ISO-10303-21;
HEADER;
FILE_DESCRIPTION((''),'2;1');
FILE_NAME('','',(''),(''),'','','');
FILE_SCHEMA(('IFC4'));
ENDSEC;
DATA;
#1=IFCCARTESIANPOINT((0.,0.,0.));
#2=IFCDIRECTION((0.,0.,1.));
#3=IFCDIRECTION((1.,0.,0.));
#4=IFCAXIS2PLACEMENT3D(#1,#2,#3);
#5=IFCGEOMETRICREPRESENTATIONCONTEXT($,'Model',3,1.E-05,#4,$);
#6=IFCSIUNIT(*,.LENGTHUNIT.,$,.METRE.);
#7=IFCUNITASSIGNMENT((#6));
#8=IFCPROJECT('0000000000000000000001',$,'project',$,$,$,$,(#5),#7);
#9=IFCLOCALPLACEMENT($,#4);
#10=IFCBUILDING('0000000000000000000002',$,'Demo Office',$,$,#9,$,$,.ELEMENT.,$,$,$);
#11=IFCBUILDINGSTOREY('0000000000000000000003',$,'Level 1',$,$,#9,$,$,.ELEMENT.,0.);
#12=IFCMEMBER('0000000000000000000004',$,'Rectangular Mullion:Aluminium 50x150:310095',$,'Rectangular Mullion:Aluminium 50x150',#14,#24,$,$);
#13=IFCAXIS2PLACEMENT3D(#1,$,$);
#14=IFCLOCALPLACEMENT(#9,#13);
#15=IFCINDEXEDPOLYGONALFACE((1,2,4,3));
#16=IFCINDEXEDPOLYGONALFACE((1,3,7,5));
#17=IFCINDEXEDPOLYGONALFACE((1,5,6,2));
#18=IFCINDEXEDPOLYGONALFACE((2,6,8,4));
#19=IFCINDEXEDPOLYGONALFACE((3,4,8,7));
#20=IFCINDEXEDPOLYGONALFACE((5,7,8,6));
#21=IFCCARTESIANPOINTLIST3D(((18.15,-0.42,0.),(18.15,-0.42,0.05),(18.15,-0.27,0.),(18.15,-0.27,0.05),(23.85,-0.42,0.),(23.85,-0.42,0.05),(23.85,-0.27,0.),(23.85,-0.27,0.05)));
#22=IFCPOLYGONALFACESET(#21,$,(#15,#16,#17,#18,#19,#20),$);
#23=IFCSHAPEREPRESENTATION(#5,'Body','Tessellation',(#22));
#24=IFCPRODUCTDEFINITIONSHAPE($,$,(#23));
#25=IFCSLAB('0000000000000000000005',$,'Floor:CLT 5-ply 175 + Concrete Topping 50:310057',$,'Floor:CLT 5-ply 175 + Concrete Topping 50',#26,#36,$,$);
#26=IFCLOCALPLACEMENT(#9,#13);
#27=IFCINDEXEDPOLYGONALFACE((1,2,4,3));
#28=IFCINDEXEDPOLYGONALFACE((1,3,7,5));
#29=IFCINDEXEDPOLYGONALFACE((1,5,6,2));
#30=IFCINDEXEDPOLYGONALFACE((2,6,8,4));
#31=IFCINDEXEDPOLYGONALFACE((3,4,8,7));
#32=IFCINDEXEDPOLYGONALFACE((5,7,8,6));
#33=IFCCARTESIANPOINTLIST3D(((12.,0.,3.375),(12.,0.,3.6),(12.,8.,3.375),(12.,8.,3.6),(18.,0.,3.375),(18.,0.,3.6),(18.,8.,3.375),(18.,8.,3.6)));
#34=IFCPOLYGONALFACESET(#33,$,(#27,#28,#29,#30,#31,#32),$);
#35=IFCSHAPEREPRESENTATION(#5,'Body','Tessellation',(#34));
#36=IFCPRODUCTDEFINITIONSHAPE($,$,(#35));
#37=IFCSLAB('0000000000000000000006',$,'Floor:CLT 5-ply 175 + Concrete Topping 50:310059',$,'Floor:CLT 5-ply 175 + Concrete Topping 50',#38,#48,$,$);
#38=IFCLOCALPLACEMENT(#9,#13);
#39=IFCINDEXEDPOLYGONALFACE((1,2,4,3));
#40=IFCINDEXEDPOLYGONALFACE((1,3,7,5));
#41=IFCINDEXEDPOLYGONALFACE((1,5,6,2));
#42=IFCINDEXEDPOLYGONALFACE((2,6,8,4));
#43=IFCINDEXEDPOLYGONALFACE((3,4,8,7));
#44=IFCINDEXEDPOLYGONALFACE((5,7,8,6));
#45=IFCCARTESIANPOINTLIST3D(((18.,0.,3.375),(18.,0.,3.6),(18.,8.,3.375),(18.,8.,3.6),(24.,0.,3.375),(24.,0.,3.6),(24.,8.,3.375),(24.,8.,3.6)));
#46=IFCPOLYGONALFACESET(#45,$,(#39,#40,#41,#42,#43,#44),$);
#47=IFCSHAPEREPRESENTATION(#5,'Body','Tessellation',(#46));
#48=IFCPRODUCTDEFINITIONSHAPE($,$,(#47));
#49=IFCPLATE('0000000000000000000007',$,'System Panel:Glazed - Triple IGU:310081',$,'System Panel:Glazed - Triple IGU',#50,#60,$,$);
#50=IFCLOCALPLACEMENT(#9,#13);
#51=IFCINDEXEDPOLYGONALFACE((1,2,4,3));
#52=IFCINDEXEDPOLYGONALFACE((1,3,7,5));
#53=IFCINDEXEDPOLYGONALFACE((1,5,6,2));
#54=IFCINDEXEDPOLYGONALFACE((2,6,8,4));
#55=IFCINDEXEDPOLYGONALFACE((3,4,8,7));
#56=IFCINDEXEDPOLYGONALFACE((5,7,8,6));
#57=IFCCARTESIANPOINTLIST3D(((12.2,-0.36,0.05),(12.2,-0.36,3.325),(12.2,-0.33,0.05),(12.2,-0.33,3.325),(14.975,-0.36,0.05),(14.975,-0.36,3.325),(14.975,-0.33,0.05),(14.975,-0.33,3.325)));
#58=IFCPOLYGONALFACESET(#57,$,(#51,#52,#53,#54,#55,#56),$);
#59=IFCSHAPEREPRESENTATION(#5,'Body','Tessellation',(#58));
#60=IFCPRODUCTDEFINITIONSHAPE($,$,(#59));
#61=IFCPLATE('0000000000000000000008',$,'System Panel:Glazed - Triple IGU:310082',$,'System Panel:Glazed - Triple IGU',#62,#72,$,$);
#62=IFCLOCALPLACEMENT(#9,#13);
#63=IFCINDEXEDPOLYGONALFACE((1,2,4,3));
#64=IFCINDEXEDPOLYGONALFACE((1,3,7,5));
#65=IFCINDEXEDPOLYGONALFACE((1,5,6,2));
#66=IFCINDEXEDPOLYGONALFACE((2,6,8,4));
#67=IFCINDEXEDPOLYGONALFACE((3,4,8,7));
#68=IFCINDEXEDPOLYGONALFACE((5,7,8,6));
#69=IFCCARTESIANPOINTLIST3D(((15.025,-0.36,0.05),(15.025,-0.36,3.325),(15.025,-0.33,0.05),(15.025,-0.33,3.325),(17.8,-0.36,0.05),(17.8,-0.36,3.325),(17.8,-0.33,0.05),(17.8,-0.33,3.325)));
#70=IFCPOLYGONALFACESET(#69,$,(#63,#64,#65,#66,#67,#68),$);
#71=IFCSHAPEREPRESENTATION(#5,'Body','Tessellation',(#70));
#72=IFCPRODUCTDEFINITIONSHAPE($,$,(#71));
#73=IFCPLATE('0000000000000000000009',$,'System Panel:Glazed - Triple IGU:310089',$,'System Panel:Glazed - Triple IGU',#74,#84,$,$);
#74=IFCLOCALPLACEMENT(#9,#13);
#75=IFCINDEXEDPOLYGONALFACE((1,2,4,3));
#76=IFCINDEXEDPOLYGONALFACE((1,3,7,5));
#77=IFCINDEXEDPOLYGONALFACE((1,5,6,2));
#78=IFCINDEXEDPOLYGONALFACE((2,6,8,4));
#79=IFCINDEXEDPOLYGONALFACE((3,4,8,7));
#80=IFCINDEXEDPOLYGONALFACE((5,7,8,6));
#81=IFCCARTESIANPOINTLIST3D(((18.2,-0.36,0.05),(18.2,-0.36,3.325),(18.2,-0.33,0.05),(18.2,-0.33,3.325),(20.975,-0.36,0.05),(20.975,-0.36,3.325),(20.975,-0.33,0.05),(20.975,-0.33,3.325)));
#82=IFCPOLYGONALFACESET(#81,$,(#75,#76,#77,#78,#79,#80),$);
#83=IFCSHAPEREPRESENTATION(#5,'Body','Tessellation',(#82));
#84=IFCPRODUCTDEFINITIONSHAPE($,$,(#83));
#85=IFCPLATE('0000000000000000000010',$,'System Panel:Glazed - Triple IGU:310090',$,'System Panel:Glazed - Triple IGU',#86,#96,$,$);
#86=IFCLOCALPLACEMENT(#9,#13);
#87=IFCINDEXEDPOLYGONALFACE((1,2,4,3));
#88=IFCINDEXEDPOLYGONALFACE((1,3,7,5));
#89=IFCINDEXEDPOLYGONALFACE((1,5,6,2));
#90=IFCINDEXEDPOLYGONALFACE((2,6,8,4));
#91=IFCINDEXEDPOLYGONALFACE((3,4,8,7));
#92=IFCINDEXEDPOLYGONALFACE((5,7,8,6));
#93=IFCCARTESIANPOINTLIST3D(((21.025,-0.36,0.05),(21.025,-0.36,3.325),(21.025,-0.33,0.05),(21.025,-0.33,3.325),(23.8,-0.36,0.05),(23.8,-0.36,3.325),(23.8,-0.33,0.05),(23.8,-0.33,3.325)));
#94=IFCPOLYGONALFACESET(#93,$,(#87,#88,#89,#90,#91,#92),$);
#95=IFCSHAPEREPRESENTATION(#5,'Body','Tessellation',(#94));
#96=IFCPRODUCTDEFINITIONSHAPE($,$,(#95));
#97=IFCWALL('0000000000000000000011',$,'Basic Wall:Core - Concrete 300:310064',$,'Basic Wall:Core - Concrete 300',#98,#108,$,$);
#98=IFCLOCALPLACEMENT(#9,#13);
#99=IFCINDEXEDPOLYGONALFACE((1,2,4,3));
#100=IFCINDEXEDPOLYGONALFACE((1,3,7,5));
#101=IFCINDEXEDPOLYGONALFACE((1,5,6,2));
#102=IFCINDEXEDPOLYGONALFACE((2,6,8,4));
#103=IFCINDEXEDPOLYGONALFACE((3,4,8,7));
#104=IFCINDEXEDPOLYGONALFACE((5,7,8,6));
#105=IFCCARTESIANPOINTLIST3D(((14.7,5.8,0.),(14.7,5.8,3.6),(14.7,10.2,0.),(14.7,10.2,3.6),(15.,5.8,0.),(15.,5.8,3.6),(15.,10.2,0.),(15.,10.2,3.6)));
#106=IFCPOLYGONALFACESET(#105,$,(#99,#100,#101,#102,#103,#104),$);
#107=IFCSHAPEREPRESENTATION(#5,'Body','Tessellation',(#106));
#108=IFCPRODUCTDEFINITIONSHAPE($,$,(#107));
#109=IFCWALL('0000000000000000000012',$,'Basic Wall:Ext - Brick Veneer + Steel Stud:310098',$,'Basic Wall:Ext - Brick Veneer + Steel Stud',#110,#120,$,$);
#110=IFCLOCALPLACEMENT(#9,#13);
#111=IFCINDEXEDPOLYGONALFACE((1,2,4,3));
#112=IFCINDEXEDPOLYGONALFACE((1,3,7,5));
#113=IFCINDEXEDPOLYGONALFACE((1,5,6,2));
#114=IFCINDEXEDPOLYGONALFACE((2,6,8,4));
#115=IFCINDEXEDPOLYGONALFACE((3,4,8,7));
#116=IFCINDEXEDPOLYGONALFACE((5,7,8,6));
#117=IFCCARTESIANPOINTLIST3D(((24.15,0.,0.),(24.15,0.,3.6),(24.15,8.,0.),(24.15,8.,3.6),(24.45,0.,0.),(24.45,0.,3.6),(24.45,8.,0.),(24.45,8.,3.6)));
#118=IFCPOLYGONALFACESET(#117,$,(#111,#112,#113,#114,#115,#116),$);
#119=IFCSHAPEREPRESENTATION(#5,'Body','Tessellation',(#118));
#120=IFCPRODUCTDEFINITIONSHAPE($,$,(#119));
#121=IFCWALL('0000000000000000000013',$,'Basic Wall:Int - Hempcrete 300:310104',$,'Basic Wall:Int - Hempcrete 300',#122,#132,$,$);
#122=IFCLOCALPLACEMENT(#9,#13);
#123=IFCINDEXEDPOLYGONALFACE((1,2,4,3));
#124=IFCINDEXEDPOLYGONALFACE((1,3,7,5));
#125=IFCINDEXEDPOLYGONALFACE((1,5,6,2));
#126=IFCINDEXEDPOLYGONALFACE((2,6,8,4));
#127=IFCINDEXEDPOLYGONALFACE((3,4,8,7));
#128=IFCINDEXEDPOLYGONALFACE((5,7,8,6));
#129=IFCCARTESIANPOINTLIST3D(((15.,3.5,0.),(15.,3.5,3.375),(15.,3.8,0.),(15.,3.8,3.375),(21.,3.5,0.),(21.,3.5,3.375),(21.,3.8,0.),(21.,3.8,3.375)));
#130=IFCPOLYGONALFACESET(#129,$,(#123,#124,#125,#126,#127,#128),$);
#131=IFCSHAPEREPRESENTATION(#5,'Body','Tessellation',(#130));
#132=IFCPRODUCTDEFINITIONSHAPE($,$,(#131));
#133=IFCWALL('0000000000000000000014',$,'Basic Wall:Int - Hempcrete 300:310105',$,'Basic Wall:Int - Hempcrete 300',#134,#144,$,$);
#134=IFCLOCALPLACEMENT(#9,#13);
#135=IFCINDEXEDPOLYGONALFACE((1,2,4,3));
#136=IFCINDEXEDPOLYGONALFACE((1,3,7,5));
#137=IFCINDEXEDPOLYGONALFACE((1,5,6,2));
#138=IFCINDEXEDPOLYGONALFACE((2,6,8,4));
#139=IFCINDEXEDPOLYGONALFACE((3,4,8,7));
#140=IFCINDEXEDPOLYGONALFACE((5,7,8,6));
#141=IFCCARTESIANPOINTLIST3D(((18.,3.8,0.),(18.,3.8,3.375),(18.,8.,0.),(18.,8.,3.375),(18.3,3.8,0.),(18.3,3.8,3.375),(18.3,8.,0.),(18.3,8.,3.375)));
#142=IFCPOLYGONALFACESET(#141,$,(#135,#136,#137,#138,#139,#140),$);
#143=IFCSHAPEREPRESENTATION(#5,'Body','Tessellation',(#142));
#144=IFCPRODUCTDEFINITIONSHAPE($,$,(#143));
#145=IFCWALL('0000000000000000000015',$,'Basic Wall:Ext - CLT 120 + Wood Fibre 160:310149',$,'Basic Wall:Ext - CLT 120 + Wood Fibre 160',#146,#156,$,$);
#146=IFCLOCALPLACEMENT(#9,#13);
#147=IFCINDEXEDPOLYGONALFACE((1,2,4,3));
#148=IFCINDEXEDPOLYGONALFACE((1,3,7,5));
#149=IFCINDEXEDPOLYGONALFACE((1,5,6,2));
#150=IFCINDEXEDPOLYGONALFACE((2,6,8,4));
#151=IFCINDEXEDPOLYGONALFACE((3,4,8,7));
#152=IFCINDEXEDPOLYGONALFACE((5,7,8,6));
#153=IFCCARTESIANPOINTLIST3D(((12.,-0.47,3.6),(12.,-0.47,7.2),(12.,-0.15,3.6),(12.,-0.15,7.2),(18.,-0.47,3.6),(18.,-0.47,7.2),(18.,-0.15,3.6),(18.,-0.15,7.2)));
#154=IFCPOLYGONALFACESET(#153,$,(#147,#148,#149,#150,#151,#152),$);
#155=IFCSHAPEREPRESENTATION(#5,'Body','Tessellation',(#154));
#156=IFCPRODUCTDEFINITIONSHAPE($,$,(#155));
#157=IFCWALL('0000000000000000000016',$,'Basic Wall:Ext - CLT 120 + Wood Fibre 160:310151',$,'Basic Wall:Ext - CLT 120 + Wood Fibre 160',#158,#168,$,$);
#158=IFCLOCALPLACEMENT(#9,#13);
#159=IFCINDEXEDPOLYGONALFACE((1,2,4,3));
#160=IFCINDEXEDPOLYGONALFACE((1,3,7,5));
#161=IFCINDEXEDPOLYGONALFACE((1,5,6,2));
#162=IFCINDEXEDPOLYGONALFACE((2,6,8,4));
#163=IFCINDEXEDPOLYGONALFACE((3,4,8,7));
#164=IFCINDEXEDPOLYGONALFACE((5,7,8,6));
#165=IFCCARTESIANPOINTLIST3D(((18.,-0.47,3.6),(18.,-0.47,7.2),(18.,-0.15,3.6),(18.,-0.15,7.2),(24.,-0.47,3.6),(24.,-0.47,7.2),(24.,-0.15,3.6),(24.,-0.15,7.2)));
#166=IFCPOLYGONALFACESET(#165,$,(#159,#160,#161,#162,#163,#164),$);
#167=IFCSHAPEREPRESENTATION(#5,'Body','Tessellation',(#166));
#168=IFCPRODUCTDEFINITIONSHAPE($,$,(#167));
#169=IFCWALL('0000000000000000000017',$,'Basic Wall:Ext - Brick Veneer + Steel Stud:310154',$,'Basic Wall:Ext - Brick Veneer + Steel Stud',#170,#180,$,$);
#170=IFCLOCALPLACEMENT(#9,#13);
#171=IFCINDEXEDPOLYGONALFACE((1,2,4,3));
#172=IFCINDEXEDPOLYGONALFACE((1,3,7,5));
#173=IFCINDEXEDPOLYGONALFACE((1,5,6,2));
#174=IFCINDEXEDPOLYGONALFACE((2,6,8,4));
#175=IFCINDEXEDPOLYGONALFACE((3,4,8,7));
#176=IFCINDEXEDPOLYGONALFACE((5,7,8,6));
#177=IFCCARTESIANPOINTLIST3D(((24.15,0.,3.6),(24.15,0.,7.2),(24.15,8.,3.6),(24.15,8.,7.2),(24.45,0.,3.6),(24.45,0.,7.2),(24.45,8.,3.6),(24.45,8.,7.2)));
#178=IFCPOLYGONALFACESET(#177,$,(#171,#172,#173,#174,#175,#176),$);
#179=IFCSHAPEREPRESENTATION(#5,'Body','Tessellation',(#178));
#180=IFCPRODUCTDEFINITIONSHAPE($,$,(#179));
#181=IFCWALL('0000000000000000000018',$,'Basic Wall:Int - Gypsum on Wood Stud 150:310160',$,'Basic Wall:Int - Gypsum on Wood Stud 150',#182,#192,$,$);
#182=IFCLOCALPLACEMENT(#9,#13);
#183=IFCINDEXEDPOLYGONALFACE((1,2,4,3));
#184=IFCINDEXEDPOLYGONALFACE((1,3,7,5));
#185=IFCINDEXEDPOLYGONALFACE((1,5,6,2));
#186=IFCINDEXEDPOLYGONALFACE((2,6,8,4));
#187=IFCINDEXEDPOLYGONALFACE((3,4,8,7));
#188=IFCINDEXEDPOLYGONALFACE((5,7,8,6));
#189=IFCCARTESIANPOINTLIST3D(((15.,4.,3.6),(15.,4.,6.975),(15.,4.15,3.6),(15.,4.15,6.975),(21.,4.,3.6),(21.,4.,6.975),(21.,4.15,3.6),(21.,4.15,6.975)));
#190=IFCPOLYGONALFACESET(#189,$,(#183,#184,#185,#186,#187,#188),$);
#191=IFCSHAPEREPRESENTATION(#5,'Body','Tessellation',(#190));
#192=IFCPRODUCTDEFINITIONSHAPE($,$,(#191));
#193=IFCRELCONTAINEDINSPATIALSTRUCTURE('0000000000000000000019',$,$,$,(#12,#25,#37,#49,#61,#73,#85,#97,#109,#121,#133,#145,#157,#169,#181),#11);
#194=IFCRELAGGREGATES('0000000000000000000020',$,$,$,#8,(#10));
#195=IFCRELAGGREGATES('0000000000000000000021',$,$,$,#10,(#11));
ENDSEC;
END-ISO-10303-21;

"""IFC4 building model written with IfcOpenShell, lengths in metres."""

from ifc_helpers import new_model, si_unit, frame, origin_with_axes, origin_2d, place, context, project, spatial, rectangle, extrude, element, save


model = new_model("IFC4")

# Units and contexts
model_context = context("Model", 3, precision=1e-05, world=origin_with_axes())
ifc_project = project(units=[si_unit("LENGTHUNIT", "METRE")], contexts=[model_context])

# Building, storey
placement = place(None, origin_with_axes())
building = spatial("IfcBuilding", under=ifc_project, at=placement, Name="Demo Office", CompositionType="ELEMENT")
storey = spatial("IfcBuildingStorey", under=building, at=placement, Name="Level 1", CompositionType="ELEMENT", Elevation=0.0)

# Member
for number, where, name in (
    (1, (21.0, -0.345, 0.0), "Rectangular Mullion:Aluminium 50x150:310095"),
):
    element("IfcMember", number, at=place(placement, frame(where)), inside=storey, Name=name, ObjectType="Rectangular Mullion:Aluminium 50x150", context=model_context, shape_type="SweptSolid", body=[
        extrude(rectangle(XDim=5.7, YDim=0.15, at=origin_2d()), origin_with_axes(), (0.0, 0.0, 1.0), 0.05),
    ])

# Slabs
for number, where, name in (
    (2, (15.0, 4.0, 3.375), "Floor:CLT 5-ply 175 + Concrete Topping 50:310057"),
    (3, (21.0, 4.0, 3.375), "Floor:CLT 5-ply 175 + Concrete Topping 50:310059"),
):
    element("IfcSlab", number, at=place(placement, frame(where)), inside=storey, Name=name, ObjectType="Floor:CLT 5-ply 175 + Concrete Topping 50", context=model_context, shape_type="SweptSolid", body=[
        extrude(rectangle(XDim=6.0, YDim=8.0, at=origin_2d()), origin_with_axes(), (0.0, 0.0, 1.0), 0.225),
    ])

# Plates
for number, where, name in (
    (4, (13.5875, -0.345, 0.05), "System Panel:Glazed - Triple IGU:310081"),
    (5, (16.4125, -0.345, 0.05), "System Panel:Glazed - Triple IGU:310082"),
    (6, (19.5875, -0.345, 0.05), "System Panel:Glazed - Triple IGU:310089"),
    (7, (22.4125, -0.345, 0.05), "System Panel:Glazed - Triple IGU:310090"),
):
    element("IfcPlate", number, at=place(placement, frame(where)), inside=storey, Name=name, ObjectType="System Panel:Glazed - Triple IGU", context=model_context, shape_type="SweptSolid", body=[
        extrude(rectangle(XDim=2.775, YDim=0.03, at=origin_2d()), origin_with_axes(), (0.0, 0.0, 1.0), 3.275),
    ])

# Walls
wall_1_placement = place(placement, frame((14.85, 8.0, 0.0)))
element("IfcWall", 8, at=wall_1_placement, inside=storey, Name="Basic Wall:Core - Concrete 300:310064", ObjectType="Basic Wall:Core - Concrete 300", context=model_context, shape_type="SweptSolid", body=[
    extrude(rectangle(XDim=0.3, YDim=4.4, at=origin_2d()), origin_with_axes(), (0.0, 0.0, 1.0), 3.6),
])
wall_2_placement = place(placement, frame((24.3, 4.0, 0.0)))
element("IfcWall", 9, at=wall_2_placement, inside=storey, Name="Basic Wall:Ext - Brick Veneer + Steel Stud:310098", ObjectType="Basic Wall:Ext - Brick Veneer + Steel Stud", context=model_context, shape_type="SweptSolid", body=[
    extrude(rectangle(XDim=0.3, YDim=8.0, at=origin_2d()), origin_with_axes(), (0.0, 0.0, 1.0), 3.6),
])
wall_3_placement = place(placement, frame((18.0, 3.65, 0.0)))
element("IfcWall", 10, at=wall_3_placement, inside=storey, Name="Basic Wall:Int - Hempcrete 300:310104", ObjectType="Basic Wall:Int - Hempcrete 300", context=model_context, shape_type="SweptSolid", body=[
    extrude(rectangle(XDim=6.0, YDim=0.3, at=origin_2d()), origin_with_axes(), (0.0, 0.0, 1.0), 3.375),
])
wall_4_placement = place(placement, frame((18.15, 5.9, 0.0)))
element("IfcWall", 11, at=wall_4_placement, inside=storey, Name="Basic Wall:Int - Hempcrete 300:310105", ObjectType="Basic Wall:Int - Hempcrete 300", context=model_context, shape_type="SweptSolid", body=[
    extrude(rectangle(XDim=0.3, YDim=4.2, at=origin_2d()), origin_with_axes(), (0.0, 0.0, 1.0), 3.375),
])
for number, where, name in (
    (12, (15.0, -0.31, 3.6), "Basic Wall:Ext - CLT 120 + Wood Fibre 160:310149"),
    (13, (21.0, -0.31, 3.6), "Basic Wall:Ext - CLT 120 + Wood Fibre 160:310151"),
):
    element("IfcWall", number, at=place(placement, frame(where)), inside=storey, Name=name, ObjectType="Basic Wall:Ext - CLT 120 + Wood Fibre 160", context=model_context, shape_type="SweptSolid", body=[
        extrude(rectangle(XDim=6.0, YDim=0.32, at=origin_2d()), origin_with_axes(), (0.0, 0.0, 1.0), 3.6),
    ])
wall_5_placement = place(placement, frame((24.3, 4.0, 3.6)))
element("IfcWall", 14, at=wall_5_placement, inside=storey, Name="Basic Wall:Ext - Brick Veneer + Steel Stud:310154", ObjectType="Basic Wall:Ext - Brick Veneer + Steel Stud", context=model_context, shape_type="SweptSolid", body=[
    extrude(rectangle(XDim=0.3, YDim=8.0, at=origin_2d()), origin_with_axes(), (0.0, 0.0, 1.0), 3.6),
])
wall_6_placement = place(placement, frame((18.0, 4.075, 3.6)))
element("IfcWall", 15, at=wall_6_placement, inside=storey, Name="Basic Wall:Int - Gypsum on Wood Stud 150:310160", ObjectType="Basic Wall:Int - Gypsum on Wood Stud 150", context=model_context, shape_type="SweptSolid", body=[
    extrude(rectangle(XDim=6.0, YDim=0.15, at=origin_2d()), origin_with_axes(), (0.0, 0.0, 1.0), 3.375),
])

save(model, "model.ifc")
